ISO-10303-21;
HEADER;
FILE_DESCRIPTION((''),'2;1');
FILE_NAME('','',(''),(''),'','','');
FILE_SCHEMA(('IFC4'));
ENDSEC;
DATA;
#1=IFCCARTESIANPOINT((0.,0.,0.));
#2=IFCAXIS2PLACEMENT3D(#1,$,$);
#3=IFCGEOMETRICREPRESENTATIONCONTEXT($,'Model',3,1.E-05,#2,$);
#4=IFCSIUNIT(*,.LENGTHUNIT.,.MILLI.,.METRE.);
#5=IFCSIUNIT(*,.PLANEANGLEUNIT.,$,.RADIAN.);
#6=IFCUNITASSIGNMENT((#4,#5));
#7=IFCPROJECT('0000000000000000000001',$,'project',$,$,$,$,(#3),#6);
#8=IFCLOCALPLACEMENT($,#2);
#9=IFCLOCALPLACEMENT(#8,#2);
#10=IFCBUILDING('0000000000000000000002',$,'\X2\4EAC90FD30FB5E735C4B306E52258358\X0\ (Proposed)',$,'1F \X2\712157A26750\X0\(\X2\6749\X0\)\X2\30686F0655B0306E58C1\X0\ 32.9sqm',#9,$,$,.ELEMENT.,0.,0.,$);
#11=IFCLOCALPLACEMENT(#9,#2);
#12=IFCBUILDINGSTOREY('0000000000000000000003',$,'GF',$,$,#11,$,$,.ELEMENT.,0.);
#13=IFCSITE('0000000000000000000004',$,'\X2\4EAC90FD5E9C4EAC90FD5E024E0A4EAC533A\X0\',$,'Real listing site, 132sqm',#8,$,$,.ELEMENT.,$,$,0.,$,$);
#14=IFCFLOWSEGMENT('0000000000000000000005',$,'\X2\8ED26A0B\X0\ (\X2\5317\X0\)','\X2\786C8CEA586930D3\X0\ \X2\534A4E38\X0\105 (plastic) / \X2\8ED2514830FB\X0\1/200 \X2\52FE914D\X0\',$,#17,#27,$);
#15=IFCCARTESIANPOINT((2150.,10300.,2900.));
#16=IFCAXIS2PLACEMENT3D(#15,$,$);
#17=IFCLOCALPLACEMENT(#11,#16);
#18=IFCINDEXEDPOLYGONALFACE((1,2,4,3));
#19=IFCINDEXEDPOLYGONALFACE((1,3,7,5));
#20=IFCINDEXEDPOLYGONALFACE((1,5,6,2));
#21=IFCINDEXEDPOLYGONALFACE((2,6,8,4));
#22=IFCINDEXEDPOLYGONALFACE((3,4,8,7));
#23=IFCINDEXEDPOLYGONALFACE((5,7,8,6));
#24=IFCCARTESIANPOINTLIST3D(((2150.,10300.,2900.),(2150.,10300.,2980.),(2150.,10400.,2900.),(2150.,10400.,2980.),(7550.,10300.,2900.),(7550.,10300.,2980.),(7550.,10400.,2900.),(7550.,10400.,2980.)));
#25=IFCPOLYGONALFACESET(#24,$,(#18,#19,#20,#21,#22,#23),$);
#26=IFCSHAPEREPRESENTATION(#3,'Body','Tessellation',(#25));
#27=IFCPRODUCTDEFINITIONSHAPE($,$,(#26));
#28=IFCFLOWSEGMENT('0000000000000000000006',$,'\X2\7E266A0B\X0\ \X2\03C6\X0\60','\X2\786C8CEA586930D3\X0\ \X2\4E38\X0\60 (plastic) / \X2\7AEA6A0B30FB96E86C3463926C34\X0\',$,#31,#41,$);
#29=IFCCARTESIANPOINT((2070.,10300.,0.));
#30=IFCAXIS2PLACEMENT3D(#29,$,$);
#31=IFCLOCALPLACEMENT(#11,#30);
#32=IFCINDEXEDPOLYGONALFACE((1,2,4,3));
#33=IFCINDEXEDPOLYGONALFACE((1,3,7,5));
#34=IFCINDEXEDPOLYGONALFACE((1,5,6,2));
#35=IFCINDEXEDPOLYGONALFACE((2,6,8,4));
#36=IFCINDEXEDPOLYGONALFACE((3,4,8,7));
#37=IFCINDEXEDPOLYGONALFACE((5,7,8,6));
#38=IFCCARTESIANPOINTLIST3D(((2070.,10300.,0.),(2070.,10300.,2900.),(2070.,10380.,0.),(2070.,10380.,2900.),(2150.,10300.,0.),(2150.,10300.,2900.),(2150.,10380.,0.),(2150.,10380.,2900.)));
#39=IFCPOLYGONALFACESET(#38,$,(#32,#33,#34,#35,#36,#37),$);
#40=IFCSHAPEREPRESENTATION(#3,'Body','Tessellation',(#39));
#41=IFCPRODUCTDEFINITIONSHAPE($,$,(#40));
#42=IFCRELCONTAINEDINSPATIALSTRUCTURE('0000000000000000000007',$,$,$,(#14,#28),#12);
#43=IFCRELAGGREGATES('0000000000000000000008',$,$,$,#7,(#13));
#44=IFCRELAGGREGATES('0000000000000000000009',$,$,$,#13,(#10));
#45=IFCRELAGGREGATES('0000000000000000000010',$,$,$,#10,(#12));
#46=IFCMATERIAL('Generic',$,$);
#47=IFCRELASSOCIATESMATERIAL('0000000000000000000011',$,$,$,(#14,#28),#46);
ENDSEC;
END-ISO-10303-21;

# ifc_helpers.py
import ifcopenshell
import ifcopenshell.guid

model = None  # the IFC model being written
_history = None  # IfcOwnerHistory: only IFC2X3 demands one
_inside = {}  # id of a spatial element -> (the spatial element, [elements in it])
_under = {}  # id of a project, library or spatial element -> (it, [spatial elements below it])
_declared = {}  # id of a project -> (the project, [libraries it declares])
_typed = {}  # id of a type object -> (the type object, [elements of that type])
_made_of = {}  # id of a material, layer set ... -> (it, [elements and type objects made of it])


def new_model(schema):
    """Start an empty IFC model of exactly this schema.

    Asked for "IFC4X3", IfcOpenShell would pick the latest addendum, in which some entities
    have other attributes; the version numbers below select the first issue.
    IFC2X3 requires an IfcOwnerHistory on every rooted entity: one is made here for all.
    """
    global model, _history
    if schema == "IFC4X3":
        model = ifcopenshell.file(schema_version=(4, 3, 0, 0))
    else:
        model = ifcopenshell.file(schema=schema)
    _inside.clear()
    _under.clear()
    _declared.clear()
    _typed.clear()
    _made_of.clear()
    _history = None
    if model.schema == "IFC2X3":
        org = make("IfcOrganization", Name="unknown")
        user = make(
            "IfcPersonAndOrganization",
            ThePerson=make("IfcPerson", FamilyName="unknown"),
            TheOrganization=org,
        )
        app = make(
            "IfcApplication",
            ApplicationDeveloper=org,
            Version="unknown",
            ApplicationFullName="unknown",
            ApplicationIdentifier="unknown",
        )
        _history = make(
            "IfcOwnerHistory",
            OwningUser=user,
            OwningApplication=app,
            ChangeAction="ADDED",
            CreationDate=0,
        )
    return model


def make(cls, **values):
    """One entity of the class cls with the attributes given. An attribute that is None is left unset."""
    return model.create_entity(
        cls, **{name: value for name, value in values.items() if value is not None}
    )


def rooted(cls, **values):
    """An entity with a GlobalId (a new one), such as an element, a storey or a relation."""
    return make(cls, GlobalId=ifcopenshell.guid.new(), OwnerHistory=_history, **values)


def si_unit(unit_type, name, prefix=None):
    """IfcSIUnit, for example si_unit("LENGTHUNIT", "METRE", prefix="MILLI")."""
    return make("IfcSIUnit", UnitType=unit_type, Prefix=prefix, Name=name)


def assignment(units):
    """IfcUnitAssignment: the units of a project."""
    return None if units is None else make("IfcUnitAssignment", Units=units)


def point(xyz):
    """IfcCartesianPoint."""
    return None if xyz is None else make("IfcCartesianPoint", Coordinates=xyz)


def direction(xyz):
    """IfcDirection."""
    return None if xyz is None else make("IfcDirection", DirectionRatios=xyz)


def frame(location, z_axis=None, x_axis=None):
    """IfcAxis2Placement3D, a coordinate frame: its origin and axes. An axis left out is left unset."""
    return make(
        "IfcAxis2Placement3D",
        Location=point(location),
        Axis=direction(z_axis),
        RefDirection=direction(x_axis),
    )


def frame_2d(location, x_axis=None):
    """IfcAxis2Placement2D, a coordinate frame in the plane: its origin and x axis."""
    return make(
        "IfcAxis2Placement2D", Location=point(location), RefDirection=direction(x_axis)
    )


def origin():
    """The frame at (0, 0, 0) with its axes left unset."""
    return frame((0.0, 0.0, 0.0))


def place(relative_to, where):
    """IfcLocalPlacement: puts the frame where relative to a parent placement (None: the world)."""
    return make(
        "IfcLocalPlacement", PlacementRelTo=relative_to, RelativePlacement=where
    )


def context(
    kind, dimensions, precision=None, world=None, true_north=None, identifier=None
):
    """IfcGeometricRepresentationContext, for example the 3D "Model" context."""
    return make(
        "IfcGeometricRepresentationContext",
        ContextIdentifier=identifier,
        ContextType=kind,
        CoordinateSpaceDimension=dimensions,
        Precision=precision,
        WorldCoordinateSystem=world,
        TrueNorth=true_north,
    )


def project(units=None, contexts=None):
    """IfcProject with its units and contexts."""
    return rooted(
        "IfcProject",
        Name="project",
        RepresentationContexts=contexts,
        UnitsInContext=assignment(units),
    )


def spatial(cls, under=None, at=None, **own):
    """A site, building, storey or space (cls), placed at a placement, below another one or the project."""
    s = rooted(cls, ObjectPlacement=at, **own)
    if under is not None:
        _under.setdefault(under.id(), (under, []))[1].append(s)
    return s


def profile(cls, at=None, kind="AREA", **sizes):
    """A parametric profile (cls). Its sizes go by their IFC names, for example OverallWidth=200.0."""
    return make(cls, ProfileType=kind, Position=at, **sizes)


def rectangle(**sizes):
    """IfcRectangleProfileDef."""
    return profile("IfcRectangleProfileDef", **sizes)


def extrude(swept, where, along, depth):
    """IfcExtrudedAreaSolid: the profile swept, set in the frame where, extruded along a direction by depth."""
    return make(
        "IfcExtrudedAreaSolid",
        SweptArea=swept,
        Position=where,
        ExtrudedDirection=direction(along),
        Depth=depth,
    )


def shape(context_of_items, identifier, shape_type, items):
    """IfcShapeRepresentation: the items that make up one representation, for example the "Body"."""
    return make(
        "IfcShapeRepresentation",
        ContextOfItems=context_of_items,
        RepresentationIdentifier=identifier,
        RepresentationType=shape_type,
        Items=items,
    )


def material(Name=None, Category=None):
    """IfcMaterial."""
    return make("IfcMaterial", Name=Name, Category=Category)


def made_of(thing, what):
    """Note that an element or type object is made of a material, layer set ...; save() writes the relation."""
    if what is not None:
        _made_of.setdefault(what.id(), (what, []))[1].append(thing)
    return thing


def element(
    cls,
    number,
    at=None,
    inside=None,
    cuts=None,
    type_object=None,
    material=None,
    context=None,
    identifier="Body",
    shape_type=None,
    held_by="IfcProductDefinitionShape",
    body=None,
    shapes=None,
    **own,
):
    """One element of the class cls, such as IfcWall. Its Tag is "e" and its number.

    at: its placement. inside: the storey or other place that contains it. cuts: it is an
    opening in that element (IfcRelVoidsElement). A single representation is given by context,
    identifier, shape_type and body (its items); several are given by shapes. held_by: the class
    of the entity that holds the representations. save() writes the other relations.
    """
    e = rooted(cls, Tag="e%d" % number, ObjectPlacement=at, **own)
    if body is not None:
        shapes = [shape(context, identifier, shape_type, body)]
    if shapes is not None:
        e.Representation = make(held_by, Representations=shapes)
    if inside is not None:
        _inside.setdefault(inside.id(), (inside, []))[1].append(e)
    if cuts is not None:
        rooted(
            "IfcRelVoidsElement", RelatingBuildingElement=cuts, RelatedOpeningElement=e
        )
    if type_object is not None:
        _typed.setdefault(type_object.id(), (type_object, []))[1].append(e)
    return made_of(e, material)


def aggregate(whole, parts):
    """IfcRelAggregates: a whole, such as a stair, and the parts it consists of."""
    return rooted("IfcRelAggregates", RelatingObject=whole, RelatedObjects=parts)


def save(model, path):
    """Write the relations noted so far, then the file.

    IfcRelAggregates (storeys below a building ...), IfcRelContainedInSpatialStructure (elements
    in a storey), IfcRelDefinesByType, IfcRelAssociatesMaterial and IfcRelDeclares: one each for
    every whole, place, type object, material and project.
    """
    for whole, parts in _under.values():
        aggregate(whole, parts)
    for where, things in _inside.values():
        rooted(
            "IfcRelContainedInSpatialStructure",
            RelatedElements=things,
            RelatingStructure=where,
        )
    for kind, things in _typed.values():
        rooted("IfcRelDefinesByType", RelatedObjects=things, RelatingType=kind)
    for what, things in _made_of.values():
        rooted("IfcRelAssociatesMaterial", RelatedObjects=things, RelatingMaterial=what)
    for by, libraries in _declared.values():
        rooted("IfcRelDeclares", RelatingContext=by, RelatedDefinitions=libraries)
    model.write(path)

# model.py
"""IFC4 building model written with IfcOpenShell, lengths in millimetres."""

from ifc_helpers import new_model, si_unit, frame, frame_2d, origin, place, context, project, spatial, rectangle, extrude, material, element, save


model = new_model("IFC4")

# Units and contexts
model_context = context("Model", 3, precision=1e-05, world=origin())
ifc_project = project(units=[si_unit("LENGTHUNIT", "METRE", prefix="MILLI"), si_unit("PLANEANGLEUNIT", "RADIAN")], contexts=[model_context])

# Site, building, storey
site_placement = place(None, origin())
site = spatial("IfcSite", under=ifc_project, at=site_placement, Name="京都府京都市上京区", ObjectType="Real listing site, 132sqm", CompositionType="ELEMENT", RefElevation=0.0)
building_placement = place(site_placement, origin())
building = spatial("IfcBuilding", under=site, at=building_placement, Name="京都・平屋の別荘 (Proposed)", ObjectType="1F 無垢材(杉)と漆喰の壁 32.9sqm", CompositionType="ELEMENT", ElevationOfRefHeight=0.0, ElevationOfTerrain=0.0)
storey_placement = place(building_placement, origin())
storey = spatial("IfcBuildingStorey", under=building, at=storey_placement, Name="GF", CompositionType="ELEMENT", Elevation=0.0)

# Shared definitions
ifc_material_1 = material(Name="Generic")

# Flow segments
flow_segment_1_placement = place(storey_placement, frame((2150.0, 10300.0, 2900.0)))
element("IfcFlowSegment", 1, at=flow_segment_1_placement, inside=storey, material=ifc_material_1, Name="軒樋 (北)", Description="硬質塩ビ 半丸105 (plastic) / 軒先・1/200 勾配", context=model_context, shape_type="SweptSolid", body=[
    extrude(rectangle(XDim=5400.0, YDim=100.0, at=frame_2d((2700.0, 50.0))), frame((2150.0, 10300.0, 2900.0)), (0.0, 0.0, 1.0), 80.0),
])
flow_segment_2_placement = place(storey_placement, frame((2070.0, 10300.0, 0.0)))
element("IfcFlowSegment", 2, at=flow_segment_2_placement, inside=storey, material=ifc_material_1, Name="縦樋 φ60", Description="硬質塩ビ 丸60 (plastic) / 竪樋・雨水排水", context=model_context, shape_type="SweptSolid", body=[
    extrude(rectangle(XDim=80.0, YDim=80.0, at=frame_2d((40.0, 40.0))), frame((2070.0, 10300.0, 0.0)), (0.0, 0.0, 1.0), 2900.0),
])

save(model, "model.ifc")
